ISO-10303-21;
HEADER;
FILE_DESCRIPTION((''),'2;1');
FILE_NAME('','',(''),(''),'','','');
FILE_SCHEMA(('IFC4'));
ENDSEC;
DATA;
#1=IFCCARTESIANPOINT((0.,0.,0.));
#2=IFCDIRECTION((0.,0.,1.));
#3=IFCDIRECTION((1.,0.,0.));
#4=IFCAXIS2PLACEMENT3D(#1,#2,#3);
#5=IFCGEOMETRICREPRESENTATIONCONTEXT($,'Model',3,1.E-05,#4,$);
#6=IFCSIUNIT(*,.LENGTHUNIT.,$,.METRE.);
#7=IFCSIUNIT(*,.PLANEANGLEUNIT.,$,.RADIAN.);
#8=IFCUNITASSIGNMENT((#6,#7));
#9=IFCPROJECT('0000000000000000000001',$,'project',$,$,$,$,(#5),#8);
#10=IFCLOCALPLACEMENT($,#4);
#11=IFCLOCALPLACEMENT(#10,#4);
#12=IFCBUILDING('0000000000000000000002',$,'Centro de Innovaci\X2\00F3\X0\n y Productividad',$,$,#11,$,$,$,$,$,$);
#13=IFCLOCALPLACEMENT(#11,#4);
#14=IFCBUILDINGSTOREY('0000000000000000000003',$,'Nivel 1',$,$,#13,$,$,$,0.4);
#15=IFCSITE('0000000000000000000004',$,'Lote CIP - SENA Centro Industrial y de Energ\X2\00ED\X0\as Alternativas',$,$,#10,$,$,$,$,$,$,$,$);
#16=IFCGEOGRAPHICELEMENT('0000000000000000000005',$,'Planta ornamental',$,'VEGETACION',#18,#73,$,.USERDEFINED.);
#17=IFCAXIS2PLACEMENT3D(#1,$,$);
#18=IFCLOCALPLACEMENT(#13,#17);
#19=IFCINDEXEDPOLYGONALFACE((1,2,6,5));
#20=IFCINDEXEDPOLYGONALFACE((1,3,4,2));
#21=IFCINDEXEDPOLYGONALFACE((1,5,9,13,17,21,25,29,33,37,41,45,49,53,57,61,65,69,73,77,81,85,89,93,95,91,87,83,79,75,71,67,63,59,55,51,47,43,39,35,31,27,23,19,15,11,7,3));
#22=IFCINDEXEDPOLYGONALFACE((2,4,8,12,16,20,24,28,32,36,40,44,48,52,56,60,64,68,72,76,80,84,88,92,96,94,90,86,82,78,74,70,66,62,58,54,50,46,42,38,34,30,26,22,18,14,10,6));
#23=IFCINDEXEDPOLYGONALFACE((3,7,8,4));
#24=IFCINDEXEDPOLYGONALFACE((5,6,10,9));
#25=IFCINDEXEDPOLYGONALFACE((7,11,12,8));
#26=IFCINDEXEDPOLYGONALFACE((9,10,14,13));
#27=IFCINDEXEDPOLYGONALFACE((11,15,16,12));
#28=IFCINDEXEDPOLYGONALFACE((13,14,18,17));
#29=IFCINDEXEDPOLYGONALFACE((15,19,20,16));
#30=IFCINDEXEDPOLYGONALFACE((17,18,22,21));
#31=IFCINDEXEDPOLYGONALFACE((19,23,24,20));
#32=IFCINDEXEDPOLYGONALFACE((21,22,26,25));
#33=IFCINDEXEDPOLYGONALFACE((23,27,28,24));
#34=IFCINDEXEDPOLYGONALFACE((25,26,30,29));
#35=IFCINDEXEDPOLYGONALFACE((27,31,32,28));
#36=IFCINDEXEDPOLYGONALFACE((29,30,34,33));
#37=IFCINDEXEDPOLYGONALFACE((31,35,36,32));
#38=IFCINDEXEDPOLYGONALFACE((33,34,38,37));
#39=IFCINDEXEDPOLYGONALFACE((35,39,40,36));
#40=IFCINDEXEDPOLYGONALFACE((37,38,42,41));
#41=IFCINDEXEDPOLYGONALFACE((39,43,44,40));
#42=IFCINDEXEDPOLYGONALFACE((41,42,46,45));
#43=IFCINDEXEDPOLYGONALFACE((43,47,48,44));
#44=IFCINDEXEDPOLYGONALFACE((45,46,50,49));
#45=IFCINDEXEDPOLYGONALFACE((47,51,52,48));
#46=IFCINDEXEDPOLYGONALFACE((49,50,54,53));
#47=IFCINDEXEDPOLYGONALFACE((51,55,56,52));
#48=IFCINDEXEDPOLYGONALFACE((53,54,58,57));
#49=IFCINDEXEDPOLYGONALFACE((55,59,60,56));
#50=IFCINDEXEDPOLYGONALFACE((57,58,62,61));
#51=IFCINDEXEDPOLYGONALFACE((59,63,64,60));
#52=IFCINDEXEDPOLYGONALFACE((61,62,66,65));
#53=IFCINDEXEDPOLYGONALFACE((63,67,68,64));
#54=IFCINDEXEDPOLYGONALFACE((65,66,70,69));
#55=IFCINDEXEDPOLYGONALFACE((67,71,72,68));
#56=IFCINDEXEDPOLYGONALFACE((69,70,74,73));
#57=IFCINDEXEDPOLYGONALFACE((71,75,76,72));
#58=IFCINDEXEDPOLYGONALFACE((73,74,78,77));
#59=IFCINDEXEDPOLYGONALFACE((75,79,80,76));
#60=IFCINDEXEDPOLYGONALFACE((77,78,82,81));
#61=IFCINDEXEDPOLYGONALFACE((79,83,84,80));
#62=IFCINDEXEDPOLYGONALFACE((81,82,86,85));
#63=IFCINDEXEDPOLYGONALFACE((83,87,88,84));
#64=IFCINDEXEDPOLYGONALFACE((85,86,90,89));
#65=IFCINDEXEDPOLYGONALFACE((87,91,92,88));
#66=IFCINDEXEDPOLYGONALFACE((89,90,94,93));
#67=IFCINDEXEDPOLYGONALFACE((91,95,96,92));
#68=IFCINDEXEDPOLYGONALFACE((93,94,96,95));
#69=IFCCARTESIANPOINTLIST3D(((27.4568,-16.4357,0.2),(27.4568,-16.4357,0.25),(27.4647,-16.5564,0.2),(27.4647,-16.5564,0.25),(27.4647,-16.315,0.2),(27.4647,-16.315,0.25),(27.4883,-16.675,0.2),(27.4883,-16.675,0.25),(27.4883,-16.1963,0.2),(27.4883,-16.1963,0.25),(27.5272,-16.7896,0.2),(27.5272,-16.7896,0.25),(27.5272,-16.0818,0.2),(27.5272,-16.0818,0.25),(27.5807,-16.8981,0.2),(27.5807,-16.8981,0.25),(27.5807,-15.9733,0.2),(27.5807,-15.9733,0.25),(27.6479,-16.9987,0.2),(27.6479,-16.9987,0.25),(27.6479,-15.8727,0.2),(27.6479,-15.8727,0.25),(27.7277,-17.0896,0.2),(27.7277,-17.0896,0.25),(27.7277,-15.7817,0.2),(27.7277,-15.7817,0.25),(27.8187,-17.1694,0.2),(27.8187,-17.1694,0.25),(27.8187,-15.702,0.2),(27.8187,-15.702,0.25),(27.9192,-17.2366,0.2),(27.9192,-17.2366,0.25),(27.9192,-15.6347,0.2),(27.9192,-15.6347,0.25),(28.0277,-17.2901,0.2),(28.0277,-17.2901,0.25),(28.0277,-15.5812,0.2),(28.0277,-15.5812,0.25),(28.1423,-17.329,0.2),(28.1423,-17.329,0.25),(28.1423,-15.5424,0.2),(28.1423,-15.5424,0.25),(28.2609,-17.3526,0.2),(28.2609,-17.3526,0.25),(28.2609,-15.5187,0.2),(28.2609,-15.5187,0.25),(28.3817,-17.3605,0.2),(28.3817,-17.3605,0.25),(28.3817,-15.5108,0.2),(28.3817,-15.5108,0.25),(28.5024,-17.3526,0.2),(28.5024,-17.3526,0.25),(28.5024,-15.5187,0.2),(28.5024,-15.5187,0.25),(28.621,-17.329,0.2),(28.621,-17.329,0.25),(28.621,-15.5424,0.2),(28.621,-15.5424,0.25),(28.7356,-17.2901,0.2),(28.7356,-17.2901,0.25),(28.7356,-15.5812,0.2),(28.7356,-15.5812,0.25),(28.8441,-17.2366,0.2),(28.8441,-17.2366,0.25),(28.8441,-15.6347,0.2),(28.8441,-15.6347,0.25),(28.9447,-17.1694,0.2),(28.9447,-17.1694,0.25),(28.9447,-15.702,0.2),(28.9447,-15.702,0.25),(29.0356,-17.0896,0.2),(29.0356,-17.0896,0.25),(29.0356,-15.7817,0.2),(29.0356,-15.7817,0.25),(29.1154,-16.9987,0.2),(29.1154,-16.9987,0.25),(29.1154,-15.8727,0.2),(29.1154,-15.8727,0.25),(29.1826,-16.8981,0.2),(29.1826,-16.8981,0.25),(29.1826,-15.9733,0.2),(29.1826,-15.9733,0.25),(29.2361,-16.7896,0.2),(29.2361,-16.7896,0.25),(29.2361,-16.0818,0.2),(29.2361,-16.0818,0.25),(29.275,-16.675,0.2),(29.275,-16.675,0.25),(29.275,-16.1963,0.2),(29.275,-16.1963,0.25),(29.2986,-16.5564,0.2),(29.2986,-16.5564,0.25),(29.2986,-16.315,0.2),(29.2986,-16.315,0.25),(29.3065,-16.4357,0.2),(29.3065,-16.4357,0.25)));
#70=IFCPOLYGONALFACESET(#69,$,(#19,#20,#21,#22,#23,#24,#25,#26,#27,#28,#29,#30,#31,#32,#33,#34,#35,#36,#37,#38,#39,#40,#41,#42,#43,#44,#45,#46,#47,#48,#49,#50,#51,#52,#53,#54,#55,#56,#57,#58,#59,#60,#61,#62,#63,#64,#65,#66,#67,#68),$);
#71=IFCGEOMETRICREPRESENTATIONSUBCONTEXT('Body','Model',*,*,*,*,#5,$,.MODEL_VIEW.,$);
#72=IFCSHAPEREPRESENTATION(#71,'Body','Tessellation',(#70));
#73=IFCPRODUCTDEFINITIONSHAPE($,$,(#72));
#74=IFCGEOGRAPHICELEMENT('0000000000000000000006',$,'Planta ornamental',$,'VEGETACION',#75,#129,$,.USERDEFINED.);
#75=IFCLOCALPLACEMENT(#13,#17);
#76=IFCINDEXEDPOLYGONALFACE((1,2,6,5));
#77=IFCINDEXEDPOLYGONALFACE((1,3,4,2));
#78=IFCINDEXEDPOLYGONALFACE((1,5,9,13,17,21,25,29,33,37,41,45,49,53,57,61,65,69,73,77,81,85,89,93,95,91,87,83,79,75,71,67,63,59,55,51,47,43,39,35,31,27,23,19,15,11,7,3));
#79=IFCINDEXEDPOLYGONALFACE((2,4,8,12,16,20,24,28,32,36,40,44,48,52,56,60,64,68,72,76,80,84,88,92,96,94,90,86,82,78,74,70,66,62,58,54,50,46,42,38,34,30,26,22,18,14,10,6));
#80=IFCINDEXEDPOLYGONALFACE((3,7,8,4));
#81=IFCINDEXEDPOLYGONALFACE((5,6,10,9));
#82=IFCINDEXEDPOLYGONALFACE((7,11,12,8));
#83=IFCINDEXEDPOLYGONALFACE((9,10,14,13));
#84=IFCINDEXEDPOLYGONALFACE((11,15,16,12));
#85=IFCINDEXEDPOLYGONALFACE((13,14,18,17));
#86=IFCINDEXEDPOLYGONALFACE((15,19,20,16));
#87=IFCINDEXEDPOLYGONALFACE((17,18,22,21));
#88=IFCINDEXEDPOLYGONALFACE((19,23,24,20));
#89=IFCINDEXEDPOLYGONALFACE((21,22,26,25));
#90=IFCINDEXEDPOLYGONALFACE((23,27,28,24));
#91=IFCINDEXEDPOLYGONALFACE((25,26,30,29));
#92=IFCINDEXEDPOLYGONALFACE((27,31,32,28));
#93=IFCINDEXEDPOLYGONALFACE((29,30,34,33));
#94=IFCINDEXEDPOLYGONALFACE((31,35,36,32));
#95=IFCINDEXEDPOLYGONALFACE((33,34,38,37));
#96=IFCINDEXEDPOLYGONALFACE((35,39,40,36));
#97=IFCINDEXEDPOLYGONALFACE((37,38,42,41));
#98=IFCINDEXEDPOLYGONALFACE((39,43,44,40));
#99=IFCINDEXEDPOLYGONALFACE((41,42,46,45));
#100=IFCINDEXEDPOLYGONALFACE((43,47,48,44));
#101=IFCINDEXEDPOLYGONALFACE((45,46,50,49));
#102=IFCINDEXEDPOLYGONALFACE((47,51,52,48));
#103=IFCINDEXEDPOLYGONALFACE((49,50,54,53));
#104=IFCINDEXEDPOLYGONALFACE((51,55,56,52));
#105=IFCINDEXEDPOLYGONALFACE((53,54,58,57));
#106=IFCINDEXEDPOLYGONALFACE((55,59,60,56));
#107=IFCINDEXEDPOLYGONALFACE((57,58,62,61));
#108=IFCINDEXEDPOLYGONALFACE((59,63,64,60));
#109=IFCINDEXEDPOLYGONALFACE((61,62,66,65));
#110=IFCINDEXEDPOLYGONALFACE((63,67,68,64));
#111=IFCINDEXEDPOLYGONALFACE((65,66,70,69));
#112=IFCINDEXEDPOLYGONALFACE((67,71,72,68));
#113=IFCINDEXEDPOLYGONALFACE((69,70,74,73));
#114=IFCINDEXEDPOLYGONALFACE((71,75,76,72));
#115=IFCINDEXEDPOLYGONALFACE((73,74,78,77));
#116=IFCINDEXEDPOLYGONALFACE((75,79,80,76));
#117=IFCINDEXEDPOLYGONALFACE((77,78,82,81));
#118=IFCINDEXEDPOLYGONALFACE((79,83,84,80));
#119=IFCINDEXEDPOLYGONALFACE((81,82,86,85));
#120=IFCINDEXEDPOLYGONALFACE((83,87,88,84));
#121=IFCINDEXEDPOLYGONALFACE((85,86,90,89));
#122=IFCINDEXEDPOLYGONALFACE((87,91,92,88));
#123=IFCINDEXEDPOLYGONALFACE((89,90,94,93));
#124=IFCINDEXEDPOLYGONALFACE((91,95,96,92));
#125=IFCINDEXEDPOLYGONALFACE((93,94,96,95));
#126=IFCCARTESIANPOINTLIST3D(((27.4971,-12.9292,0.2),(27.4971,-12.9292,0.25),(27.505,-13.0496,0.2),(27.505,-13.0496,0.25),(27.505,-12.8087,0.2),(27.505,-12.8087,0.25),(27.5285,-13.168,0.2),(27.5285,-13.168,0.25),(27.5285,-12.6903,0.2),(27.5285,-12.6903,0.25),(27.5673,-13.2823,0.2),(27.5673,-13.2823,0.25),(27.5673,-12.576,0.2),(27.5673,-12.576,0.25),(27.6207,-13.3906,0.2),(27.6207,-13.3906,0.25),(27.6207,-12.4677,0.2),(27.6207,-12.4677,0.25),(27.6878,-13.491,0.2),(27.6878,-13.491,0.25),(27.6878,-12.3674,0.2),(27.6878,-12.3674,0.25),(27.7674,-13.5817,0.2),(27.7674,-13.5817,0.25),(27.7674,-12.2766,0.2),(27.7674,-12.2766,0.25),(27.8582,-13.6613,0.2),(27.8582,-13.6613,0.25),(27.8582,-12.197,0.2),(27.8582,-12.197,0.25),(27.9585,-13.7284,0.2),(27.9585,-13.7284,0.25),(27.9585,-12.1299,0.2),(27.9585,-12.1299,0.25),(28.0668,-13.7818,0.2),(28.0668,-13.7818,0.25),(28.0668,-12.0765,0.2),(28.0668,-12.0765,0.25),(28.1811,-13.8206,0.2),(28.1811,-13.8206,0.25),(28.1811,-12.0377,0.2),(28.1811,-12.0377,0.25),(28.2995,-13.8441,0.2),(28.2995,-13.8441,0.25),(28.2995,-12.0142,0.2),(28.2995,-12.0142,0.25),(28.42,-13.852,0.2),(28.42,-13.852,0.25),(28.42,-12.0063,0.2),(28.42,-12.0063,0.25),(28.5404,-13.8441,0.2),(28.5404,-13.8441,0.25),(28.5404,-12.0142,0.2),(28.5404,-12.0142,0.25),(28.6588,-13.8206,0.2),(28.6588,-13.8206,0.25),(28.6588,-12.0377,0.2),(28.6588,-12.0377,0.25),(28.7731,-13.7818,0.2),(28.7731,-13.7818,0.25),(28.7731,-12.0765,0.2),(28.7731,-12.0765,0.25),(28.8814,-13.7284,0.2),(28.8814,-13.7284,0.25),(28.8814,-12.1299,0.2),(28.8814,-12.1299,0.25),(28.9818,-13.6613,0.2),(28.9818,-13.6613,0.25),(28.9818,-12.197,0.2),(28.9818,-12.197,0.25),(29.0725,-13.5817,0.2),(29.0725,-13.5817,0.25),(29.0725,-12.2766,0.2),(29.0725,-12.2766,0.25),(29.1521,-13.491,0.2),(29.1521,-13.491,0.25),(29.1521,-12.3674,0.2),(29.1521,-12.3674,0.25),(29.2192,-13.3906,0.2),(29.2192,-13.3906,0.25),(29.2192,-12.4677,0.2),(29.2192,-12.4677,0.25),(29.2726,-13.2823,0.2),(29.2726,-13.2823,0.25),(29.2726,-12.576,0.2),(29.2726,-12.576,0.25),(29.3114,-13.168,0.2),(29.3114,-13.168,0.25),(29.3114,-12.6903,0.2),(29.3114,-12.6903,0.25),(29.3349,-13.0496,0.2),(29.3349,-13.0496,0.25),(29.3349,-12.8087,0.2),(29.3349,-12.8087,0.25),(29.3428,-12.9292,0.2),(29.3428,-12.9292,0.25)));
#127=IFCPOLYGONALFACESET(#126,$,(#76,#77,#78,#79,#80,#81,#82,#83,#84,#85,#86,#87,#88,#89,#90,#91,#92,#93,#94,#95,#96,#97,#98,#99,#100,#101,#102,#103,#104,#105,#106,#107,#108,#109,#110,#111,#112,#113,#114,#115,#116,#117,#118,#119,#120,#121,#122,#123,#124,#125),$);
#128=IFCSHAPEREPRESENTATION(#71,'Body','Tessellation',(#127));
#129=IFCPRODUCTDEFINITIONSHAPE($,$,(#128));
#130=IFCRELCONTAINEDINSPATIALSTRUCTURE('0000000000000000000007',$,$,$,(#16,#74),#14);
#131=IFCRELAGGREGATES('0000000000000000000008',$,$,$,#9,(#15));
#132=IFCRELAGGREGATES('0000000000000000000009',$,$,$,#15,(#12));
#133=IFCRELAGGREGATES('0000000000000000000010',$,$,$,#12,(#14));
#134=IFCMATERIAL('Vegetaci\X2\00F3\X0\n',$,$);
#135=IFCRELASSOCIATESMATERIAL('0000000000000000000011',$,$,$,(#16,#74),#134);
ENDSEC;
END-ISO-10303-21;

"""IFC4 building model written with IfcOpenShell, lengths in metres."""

from ifc_helpers import new_model, si_unit, frame, origin_with_axes, place, context, subcontext, project, spatial, polyline, outline, extrude, material, element, save


model = new_model("IFC4")

# Units and contexts
model_context = context("Model", 3, precision=1e-05, world=origin_with_axes())
body_context = subcontext(model_context, "Body", "Model", "MODEL_VIEW")
ifc_project = project(units=[si_unit("LENGTHUNIT", "METRE"), si_unit("PLANEANGLEUNIT", "RADIAN")], contexts=[model_context])

# Site, building, storey
site_placement = place(None, origin_with_axes())
site = spatial("IfcSite", under=ifc_project, at=site_placement, Name="Lote CIP - SENA Centro Industrial y de Energías Alternativas")
building_placement = place(site_placement, origin_with_axes())
building = spatial("IfcBuilding", under=site, at=building_placement, Name="Centro de Innovación y Productividad")
storey_placement = place(building_placement, origin_with_axes())
storey = spatial("IfcBuildingStorey", under=building, at=storey_placement, Name="Nivel 1", Elevation=0.4)

# Geographic elements
ifc_material = material(Name="Vegetación")
geographic_element_1_placement = place(storey_placement, origin_with_axes())
element("IfcGeographicElement", 1, at=geographic_element_1_placement, inside=storey, material=ifc_material, Name="Planta ornamental", ObjectType="VEGETACION", PredefinedType="USERDEFINED", context=body_context, shape_type="SweptSolid", body=[
    extrude(outline(polyline([(29.3065, -16.4357), (29.2986, -16.5564), (29.275, -16.675), (29.2361, -16.7896), (29.1826, -16.8981), (29.1154, -16.9987), (29.0356, -17.0896), (28.9447, -17.1694), (28.8441, -17.2366), (28.7356, -17.2901), (28.621, -17.329), (28.5024, -17.3526), (28.3817, -17.3605), (28.2609, -17.3526), (28.1423, -17.329), (28.0277, -17.2901), (27.9192, -17.2366), (27.8187, -17.1694), (27.7277, -17.0896), (27.6479, -16.9987), (27.5807, -16.8981), (27.5272, -16.7896), (27.4883, -16.675), (27.4647, -16.5564), (27.4568, -16.4357), (27.4647, -16.315), (27.4883, -16.1963), (27.5272, -16.0818), (27.5807, -15.9733), (27.6479, -15.8727), (27.7277, -15.7817), (27.8187, -15.702), (27.9192, -15.6347), (28.0277, -15.5812), (28.1423, -15.5424), (28.2609, -15.5187), (28.3817, -15.5108), (28.5024, -15.5187), (28.621, -15.5424), (28.7356, -15.5812), (28.8441, -15.6347), (28.9447, -15.702), (29.0356, -15.7817), (29.1154, -15.8727), (29.1826, -15.9733), (29.2361, -16.0818), (29.275, -16.1963), (29.2986, -16.315), (29.3065, -16.4357)])), frame((0.0, 0.0, 0.2)), (0.0, 0.0, 1.0), 0.05),
])
geographic_element_2_placement = place(storey_placement, origin_with_axes())
element("IfcGeographicElement", 2, at=geographic_element_2_placement, inside=storey, material=ifc_material, Name="Planta ornamental", ObjectType="VEGETACION", PredefinedType="USERDEFINED", context=body_context, shape_type="SweptSolid", body=[
    extrude(outline(polyline([(29.3428, -12.9292), (29.3349, -13.0496), (29.3114, -13.168), (29.2726, -13.2823), (29.2192, -13.3906), (29.1521, -13.491), (29.0725, -13.5817), (28.9818, -13.6613), (28.8814, -13.7284), (28.7731, -13.7818), (28.6588, -13.8206), (28.5404, -13.8441), (28.42, -13.852), (28.2995, -13.8441), (28.1811, -13.8206), (28.0668, -13.7818), (27.9585, -13.7284), (27.8582, -13.6613), (27.7674, -13.5817), (27.6878, -13.491), (27.6207, -13.3906), (27.5673, -13.2823), (27.5285, -13.168), (27.505, -13.0496), (27.4971, -12.9292), (27.505, -12.8087), (27.5285, -12.6903), (27.5673, -12.576), (27.6207, -12.4677), (27.6878, -12.3674), (27.7674, -12.2766), (27.8582, -12.197), (27.9585, -12.1299), (28.0668, -12.0765), (28.1811, -12.0377), (28.2995, -12.0142), (28.42, -12.0063), (28.5404, -12.0142), (28.6588, -12.0377), (28.7731, -12.0765), (28.8814, -12.1299), (28.9818, -12.197), (29.0725, -12.2766), (29.1521, -12.3674), (29.2192, -12.4677), (29.2726, -12.576), (29.3114, -12.6903), (29.3349, -12.8087), (29.3428, -12.9292)])), frame((0.0, 0.0, 0.2)), (0.0, 0.0, 1.0), 0.05),
])

save(model, "model.ifc")
